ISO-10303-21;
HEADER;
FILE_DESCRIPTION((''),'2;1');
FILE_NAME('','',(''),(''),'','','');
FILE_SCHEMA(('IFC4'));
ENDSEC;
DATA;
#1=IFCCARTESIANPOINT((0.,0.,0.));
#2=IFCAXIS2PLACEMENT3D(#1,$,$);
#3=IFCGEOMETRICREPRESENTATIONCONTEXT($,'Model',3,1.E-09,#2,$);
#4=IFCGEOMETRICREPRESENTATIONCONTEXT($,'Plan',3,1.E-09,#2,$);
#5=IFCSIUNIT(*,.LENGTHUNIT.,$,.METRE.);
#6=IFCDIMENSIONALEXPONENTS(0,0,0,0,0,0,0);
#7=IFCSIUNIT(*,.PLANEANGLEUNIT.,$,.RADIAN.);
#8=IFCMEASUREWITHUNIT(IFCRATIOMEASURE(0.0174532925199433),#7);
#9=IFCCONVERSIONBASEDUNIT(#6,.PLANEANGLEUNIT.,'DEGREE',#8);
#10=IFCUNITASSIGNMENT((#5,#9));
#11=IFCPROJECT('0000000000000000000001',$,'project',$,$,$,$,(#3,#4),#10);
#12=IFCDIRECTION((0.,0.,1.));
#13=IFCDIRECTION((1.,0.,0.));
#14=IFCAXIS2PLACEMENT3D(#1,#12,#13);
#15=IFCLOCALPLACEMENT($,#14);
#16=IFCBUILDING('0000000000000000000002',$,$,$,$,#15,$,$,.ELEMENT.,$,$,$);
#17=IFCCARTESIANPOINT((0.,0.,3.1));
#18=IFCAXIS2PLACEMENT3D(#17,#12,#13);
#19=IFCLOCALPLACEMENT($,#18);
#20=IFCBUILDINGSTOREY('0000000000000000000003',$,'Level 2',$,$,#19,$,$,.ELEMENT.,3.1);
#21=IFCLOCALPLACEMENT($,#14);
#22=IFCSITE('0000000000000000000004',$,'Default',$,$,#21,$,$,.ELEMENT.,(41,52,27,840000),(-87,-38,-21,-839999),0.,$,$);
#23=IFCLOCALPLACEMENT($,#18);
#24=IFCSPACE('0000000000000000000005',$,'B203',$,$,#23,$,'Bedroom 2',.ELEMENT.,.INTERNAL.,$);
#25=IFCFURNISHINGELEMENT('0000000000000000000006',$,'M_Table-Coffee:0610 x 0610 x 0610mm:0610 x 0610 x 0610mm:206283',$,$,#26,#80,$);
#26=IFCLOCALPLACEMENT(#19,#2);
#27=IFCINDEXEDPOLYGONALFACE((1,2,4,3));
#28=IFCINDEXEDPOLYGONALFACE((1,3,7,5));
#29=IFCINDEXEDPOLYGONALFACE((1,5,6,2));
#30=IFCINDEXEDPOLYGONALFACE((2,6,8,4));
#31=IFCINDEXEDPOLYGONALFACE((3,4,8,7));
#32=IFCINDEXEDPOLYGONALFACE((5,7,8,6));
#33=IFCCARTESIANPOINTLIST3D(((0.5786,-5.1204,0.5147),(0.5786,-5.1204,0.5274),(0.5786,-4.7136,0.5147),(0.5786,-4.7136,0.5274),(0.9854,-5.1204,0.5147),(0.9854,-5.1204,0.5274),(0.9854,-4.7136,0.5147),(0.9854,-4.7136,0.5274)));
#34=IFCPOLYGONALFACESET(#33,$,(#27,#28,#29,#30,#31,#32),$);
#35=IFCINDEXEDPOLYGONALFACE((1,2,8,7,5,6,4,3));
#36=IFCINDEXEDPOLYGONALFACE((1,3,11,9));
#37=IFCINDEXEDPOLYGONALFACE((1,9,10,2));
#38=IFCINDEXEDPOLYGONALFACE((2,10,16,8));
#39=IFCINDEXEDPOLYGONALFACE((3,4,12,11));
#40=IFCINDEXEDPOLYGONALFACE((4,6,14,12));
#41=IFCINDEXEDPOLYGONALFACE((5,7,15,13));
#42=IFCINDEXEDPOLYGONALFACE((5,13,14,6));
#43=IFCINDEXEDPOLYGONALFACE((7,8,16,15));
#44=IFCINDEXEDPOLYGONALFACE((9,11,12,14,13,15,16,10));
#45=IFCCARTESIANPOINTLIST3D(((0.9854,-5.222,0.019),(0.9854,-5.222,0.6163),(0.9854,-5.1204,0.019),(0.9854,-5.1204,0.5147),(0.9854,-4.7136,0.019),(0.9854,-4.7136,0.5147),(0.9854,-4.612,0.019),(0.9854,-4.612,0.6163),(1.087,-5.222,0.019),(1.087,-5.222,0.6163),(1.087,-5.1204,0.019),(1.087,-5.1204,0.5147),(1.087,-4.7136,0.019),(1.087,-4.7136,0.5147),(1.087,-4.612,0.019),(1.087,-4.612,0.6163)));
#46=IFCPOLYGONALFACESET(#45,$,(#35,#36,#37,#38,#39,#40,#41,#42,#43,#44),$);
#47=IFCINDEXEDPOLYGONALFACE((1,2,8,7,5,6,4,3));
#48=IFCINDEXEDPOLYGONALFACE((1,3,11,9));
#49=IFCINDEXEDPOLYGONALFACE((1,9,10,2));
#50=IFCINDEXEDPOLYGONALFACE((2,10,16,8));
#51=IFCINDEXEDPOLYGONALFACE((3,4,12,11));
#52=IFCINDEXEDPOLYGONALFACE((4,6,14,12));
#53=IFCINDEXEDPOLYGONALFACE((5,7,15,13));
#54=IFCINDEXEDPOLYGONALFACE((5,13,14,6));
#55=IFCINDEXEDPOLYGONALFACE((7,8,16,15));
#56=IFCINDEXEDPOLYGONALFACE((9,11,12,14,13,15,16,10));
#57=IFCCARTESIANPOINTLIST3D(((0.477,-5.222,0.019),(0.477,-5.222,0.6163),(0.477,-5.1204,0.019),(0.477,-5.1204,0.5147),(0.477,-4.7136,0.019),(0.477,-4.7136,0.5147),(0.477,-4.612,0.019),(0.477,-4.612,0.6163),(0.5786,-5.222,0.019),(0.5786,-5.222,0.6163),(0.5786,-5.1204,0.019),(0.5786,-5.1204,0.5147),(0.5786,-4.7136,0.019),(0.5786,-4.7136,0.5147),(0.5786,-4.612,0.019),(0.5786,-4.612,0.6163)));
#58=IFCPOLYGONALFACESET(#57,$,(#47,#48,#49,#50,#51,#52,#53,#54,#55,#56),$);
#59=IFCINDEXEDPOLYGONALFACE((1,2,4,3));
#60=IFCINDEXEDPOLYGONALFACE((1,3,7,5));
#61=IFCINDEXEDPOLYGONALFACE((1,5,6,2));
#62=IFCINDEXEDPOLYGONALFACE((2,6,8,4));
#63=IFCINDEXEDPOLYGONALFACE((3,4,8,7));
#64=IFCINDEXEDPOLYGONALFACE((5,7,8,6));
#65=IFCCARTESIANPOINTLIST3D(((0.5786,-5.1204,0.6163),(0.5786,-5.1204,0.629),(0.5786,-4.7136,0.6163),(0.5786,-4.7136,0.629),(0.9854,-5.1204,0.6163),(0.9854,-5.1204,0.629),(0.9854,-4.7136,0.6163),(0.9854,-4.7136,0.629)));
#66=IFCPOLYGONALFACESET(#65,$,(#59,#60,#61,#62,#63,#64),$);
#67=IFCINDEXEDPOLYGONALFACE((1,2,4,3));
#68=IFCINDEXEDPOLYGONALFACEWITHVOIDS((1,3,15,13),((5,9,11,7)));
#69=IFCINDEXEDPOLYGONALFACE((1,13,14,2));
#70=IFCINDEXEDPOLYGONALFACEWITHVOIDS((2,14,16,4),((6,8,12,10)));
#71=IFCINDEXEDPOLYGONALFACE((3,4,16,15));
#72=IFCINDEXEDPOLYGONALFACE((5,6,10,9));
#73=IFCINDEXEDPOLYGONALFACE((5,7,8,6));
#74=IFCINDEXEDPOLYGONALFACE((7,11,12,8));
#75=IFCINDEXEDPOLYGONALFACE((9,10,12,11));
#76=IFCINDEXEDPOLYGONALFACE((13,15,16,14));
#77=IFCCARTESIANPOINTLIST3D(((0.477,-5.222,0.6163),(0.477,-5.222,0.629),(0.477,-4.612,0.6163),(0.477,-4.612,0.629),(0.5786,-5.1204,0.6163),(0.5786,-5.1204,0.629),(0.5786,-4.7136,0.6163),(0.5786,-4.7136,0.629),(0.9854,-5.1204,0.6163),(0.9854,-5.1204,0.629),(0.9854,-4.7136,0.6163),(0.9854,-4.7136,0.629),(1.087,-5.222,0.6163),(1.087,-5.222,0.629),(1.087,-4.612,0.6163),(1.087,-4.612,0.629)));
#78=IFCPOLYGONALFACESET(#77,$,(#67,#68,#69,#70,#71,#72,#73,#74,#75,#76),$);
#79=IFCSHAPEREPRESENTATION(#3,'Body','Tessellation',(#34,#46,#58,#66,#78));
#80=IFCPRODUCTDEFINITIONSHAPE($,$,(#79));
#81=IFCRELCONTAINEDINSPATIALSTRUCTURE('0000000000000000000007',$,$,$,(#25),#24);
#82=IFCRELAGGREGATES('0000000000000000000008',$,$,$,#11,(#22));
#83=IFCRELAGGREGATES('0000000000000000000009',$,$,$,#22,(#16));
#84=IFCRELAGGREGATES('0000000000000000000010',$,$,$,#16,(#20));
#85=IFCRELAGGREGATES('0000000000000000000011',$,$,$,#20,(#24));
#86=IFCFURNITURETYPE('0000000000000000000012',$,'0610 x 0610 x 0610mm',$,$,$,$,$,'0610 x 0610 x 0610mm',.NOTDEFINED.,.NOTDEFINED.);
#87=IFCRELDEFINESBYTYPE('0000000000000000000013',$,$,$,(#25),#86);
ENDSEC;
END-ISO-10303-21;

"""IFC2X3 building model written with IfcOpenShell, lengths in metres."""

from ifc_helpers import new_model, entity, si_unit, converted_unit, frame, origin, origin_with_axes, origin_2d_with_axis, place, context, project, spatial, polyline, rectangle, outline, extrude, source, transform, mapped, type_object, type_shapes, element, save


model = new_model("IFC2X3")

# Units and contexts
model_context = context("Model", 3, precision=1e-09, world=origin())
plan_context = context("Plan", 3, precision=1e-09, world=origin())
ifc_project = project(units=[si_unit("LENGTHUNIT", "METRE"), converted_unit("PLANEANGLEUNIT", "DEGREE", entity("IfcRatioMeasure", 0.0174532925199433), si_unit("PLANEANGLEUNIT", "RADIAN"), dimensions=[0, 0, 0, 0, 0, 0, 0])], contexts=[model_context, plan_context])

# Site, building, storey, space
site_placement = place(None, origin_with_axes())
site = spatial("IfcSite", under=ifc_project, at=site_placement, Name="Default", CompositionType="ELEMENT", RefLatitude=(41, 52, 27, 840000), RefLongitude=(-87, -38, -21, -839999), RefElevation=0.0)
building_placement = place(None, origin_with_axes())
building = spatial("IfcBuilding", under=site, at=building_placement, CompositionType="ELEMENT")
storey_placement = place(None, frame((0.0, 0.0, 3.1), z_axis=(0.0, 0.0, 1.0), x_axis=(1.0, 0.0, 0.0)))
storey = spatial("IfcBuildingStorey", under=building, at=storey_placement, Name="Level 2", CompositionType="ELEMENT", Elevation=3.1)
space_placement = place(None, frame((0.0, 0.0, 3.1), z_axis=(0.0, 0.0, 1.0), x_axis=(1.0, 0.0, 0.0)))
space = spatial("IfcSpace", under=storey, at=space_placement, Name="B203", LongName="Bedroom 2", CompositionType="ELEMENT", InteriorOrExteriorSpace="INTERNAL")

# Furnishing element
furniture_type = type_object("IfcFurnitureType", Name="0610 x 0610 x 0610mm", ElementType="0610 x 0610 x 0610mm", AssemblyPlace="NOTDEFINED")
shared_shape = source(origin(), model_context, "Body", "SweptSolid", [
    extrude(rectangle(XDim=0.4068, YDim=0.4068, at=origin_2d_with_axis()), frame((0.0183, 0.0952, 0.4957), z_axis=(0.0, 0.0, 1.0), x_axis=(-1.0, 0.0, 0.0)), (0.0, 0.0, 1.0), 0.0127),
    extrude(outline(polyline([(-0.2732, -0.305), (0.324, -0.305), (0.324, 0.305), (-0.2732, 0.305), (-0.2732, 0.2034), (0.2225, 0.2034), (0.2225, -0.2034), (-0.2732, -0.2034), (-0.2732, -0.305)])), frame((0.2217, 0.0952, 0.2732), z_axis=(1.0, 0.0, 0.0), x_axis=(0.0, 0.0, 1.0)), (0.0, 0.0, 1.0), 0.1016),
    extrude(outline(polyline([(-0.305, -0.3241), (0.305, -0.3241), (0.305, 0.2733), (0.2034, 0.2733), (0.2034, -0.2224), (-0.2034, -0.2224), (-0.2034, 0.2733), (-0.305, 0.2733), (-0.305, -0.3241)])), frame((-0.2867, 0.0952, 0.2733), z_axis=(1.0, 0.0, 0.0), x_axis=(0.0, -1.0, 0.0)), (0.0, 0.0, 1.0), 0.1016),
    extrude(rectangle(XDim=0.4068, YDim=0.4068, at=origin_2d_with_axis()), frame((0.0183, 0.0952, 0.5973), z_axis=(0.0, 0.0, 1.0), x_axis=(-1.0, 0.0, 0.0)), (0.0, 0.0, 1.0), 0.0127),
    extrude(outline(polyline([(-0.305, -0.305), (0.305, -0.305), (0.305, 0.305), (-0.305, 0.305), (-0.305, -0.305)]), holes=[polyline([(-0.2034, -0.2034), (-0.2034, 0.2034), (0.2034, 0.2034), (0.2034, -0.2034), (-0.2034, -0.2034)])]), frame((0.0183, 0.0952, 0.5973), z_axis=(0.0, 0.0, 1.0), x_axis=(-1.0, 0.0, 0.0)), (0.0, 0.0, 1.0), 0.0127),
])
type_shapes(furniture_type, [shared_shape])
furnishing_placement = place(None, frame((0.7637, -5.0122, 3.119), z_axis=(0.0, 0.0, 1.0), x_axis=(1.0, 0.0, 0.0)))
element("IfcFurnishingElement", 1, at=furnishing_placement, inside=space, type_object=furniture_type, Name="M_Table-Coffee:0610 x 0610 x 0610mm:0610 x 0610 x 0610mm:206283", context=model_context, shape_type="MappedRepresentation", body=[
    mapped(shared_shape, transform((0.0, 0.0, 0.0), scale=1.0)),
])

save(model, "model.ifc")
